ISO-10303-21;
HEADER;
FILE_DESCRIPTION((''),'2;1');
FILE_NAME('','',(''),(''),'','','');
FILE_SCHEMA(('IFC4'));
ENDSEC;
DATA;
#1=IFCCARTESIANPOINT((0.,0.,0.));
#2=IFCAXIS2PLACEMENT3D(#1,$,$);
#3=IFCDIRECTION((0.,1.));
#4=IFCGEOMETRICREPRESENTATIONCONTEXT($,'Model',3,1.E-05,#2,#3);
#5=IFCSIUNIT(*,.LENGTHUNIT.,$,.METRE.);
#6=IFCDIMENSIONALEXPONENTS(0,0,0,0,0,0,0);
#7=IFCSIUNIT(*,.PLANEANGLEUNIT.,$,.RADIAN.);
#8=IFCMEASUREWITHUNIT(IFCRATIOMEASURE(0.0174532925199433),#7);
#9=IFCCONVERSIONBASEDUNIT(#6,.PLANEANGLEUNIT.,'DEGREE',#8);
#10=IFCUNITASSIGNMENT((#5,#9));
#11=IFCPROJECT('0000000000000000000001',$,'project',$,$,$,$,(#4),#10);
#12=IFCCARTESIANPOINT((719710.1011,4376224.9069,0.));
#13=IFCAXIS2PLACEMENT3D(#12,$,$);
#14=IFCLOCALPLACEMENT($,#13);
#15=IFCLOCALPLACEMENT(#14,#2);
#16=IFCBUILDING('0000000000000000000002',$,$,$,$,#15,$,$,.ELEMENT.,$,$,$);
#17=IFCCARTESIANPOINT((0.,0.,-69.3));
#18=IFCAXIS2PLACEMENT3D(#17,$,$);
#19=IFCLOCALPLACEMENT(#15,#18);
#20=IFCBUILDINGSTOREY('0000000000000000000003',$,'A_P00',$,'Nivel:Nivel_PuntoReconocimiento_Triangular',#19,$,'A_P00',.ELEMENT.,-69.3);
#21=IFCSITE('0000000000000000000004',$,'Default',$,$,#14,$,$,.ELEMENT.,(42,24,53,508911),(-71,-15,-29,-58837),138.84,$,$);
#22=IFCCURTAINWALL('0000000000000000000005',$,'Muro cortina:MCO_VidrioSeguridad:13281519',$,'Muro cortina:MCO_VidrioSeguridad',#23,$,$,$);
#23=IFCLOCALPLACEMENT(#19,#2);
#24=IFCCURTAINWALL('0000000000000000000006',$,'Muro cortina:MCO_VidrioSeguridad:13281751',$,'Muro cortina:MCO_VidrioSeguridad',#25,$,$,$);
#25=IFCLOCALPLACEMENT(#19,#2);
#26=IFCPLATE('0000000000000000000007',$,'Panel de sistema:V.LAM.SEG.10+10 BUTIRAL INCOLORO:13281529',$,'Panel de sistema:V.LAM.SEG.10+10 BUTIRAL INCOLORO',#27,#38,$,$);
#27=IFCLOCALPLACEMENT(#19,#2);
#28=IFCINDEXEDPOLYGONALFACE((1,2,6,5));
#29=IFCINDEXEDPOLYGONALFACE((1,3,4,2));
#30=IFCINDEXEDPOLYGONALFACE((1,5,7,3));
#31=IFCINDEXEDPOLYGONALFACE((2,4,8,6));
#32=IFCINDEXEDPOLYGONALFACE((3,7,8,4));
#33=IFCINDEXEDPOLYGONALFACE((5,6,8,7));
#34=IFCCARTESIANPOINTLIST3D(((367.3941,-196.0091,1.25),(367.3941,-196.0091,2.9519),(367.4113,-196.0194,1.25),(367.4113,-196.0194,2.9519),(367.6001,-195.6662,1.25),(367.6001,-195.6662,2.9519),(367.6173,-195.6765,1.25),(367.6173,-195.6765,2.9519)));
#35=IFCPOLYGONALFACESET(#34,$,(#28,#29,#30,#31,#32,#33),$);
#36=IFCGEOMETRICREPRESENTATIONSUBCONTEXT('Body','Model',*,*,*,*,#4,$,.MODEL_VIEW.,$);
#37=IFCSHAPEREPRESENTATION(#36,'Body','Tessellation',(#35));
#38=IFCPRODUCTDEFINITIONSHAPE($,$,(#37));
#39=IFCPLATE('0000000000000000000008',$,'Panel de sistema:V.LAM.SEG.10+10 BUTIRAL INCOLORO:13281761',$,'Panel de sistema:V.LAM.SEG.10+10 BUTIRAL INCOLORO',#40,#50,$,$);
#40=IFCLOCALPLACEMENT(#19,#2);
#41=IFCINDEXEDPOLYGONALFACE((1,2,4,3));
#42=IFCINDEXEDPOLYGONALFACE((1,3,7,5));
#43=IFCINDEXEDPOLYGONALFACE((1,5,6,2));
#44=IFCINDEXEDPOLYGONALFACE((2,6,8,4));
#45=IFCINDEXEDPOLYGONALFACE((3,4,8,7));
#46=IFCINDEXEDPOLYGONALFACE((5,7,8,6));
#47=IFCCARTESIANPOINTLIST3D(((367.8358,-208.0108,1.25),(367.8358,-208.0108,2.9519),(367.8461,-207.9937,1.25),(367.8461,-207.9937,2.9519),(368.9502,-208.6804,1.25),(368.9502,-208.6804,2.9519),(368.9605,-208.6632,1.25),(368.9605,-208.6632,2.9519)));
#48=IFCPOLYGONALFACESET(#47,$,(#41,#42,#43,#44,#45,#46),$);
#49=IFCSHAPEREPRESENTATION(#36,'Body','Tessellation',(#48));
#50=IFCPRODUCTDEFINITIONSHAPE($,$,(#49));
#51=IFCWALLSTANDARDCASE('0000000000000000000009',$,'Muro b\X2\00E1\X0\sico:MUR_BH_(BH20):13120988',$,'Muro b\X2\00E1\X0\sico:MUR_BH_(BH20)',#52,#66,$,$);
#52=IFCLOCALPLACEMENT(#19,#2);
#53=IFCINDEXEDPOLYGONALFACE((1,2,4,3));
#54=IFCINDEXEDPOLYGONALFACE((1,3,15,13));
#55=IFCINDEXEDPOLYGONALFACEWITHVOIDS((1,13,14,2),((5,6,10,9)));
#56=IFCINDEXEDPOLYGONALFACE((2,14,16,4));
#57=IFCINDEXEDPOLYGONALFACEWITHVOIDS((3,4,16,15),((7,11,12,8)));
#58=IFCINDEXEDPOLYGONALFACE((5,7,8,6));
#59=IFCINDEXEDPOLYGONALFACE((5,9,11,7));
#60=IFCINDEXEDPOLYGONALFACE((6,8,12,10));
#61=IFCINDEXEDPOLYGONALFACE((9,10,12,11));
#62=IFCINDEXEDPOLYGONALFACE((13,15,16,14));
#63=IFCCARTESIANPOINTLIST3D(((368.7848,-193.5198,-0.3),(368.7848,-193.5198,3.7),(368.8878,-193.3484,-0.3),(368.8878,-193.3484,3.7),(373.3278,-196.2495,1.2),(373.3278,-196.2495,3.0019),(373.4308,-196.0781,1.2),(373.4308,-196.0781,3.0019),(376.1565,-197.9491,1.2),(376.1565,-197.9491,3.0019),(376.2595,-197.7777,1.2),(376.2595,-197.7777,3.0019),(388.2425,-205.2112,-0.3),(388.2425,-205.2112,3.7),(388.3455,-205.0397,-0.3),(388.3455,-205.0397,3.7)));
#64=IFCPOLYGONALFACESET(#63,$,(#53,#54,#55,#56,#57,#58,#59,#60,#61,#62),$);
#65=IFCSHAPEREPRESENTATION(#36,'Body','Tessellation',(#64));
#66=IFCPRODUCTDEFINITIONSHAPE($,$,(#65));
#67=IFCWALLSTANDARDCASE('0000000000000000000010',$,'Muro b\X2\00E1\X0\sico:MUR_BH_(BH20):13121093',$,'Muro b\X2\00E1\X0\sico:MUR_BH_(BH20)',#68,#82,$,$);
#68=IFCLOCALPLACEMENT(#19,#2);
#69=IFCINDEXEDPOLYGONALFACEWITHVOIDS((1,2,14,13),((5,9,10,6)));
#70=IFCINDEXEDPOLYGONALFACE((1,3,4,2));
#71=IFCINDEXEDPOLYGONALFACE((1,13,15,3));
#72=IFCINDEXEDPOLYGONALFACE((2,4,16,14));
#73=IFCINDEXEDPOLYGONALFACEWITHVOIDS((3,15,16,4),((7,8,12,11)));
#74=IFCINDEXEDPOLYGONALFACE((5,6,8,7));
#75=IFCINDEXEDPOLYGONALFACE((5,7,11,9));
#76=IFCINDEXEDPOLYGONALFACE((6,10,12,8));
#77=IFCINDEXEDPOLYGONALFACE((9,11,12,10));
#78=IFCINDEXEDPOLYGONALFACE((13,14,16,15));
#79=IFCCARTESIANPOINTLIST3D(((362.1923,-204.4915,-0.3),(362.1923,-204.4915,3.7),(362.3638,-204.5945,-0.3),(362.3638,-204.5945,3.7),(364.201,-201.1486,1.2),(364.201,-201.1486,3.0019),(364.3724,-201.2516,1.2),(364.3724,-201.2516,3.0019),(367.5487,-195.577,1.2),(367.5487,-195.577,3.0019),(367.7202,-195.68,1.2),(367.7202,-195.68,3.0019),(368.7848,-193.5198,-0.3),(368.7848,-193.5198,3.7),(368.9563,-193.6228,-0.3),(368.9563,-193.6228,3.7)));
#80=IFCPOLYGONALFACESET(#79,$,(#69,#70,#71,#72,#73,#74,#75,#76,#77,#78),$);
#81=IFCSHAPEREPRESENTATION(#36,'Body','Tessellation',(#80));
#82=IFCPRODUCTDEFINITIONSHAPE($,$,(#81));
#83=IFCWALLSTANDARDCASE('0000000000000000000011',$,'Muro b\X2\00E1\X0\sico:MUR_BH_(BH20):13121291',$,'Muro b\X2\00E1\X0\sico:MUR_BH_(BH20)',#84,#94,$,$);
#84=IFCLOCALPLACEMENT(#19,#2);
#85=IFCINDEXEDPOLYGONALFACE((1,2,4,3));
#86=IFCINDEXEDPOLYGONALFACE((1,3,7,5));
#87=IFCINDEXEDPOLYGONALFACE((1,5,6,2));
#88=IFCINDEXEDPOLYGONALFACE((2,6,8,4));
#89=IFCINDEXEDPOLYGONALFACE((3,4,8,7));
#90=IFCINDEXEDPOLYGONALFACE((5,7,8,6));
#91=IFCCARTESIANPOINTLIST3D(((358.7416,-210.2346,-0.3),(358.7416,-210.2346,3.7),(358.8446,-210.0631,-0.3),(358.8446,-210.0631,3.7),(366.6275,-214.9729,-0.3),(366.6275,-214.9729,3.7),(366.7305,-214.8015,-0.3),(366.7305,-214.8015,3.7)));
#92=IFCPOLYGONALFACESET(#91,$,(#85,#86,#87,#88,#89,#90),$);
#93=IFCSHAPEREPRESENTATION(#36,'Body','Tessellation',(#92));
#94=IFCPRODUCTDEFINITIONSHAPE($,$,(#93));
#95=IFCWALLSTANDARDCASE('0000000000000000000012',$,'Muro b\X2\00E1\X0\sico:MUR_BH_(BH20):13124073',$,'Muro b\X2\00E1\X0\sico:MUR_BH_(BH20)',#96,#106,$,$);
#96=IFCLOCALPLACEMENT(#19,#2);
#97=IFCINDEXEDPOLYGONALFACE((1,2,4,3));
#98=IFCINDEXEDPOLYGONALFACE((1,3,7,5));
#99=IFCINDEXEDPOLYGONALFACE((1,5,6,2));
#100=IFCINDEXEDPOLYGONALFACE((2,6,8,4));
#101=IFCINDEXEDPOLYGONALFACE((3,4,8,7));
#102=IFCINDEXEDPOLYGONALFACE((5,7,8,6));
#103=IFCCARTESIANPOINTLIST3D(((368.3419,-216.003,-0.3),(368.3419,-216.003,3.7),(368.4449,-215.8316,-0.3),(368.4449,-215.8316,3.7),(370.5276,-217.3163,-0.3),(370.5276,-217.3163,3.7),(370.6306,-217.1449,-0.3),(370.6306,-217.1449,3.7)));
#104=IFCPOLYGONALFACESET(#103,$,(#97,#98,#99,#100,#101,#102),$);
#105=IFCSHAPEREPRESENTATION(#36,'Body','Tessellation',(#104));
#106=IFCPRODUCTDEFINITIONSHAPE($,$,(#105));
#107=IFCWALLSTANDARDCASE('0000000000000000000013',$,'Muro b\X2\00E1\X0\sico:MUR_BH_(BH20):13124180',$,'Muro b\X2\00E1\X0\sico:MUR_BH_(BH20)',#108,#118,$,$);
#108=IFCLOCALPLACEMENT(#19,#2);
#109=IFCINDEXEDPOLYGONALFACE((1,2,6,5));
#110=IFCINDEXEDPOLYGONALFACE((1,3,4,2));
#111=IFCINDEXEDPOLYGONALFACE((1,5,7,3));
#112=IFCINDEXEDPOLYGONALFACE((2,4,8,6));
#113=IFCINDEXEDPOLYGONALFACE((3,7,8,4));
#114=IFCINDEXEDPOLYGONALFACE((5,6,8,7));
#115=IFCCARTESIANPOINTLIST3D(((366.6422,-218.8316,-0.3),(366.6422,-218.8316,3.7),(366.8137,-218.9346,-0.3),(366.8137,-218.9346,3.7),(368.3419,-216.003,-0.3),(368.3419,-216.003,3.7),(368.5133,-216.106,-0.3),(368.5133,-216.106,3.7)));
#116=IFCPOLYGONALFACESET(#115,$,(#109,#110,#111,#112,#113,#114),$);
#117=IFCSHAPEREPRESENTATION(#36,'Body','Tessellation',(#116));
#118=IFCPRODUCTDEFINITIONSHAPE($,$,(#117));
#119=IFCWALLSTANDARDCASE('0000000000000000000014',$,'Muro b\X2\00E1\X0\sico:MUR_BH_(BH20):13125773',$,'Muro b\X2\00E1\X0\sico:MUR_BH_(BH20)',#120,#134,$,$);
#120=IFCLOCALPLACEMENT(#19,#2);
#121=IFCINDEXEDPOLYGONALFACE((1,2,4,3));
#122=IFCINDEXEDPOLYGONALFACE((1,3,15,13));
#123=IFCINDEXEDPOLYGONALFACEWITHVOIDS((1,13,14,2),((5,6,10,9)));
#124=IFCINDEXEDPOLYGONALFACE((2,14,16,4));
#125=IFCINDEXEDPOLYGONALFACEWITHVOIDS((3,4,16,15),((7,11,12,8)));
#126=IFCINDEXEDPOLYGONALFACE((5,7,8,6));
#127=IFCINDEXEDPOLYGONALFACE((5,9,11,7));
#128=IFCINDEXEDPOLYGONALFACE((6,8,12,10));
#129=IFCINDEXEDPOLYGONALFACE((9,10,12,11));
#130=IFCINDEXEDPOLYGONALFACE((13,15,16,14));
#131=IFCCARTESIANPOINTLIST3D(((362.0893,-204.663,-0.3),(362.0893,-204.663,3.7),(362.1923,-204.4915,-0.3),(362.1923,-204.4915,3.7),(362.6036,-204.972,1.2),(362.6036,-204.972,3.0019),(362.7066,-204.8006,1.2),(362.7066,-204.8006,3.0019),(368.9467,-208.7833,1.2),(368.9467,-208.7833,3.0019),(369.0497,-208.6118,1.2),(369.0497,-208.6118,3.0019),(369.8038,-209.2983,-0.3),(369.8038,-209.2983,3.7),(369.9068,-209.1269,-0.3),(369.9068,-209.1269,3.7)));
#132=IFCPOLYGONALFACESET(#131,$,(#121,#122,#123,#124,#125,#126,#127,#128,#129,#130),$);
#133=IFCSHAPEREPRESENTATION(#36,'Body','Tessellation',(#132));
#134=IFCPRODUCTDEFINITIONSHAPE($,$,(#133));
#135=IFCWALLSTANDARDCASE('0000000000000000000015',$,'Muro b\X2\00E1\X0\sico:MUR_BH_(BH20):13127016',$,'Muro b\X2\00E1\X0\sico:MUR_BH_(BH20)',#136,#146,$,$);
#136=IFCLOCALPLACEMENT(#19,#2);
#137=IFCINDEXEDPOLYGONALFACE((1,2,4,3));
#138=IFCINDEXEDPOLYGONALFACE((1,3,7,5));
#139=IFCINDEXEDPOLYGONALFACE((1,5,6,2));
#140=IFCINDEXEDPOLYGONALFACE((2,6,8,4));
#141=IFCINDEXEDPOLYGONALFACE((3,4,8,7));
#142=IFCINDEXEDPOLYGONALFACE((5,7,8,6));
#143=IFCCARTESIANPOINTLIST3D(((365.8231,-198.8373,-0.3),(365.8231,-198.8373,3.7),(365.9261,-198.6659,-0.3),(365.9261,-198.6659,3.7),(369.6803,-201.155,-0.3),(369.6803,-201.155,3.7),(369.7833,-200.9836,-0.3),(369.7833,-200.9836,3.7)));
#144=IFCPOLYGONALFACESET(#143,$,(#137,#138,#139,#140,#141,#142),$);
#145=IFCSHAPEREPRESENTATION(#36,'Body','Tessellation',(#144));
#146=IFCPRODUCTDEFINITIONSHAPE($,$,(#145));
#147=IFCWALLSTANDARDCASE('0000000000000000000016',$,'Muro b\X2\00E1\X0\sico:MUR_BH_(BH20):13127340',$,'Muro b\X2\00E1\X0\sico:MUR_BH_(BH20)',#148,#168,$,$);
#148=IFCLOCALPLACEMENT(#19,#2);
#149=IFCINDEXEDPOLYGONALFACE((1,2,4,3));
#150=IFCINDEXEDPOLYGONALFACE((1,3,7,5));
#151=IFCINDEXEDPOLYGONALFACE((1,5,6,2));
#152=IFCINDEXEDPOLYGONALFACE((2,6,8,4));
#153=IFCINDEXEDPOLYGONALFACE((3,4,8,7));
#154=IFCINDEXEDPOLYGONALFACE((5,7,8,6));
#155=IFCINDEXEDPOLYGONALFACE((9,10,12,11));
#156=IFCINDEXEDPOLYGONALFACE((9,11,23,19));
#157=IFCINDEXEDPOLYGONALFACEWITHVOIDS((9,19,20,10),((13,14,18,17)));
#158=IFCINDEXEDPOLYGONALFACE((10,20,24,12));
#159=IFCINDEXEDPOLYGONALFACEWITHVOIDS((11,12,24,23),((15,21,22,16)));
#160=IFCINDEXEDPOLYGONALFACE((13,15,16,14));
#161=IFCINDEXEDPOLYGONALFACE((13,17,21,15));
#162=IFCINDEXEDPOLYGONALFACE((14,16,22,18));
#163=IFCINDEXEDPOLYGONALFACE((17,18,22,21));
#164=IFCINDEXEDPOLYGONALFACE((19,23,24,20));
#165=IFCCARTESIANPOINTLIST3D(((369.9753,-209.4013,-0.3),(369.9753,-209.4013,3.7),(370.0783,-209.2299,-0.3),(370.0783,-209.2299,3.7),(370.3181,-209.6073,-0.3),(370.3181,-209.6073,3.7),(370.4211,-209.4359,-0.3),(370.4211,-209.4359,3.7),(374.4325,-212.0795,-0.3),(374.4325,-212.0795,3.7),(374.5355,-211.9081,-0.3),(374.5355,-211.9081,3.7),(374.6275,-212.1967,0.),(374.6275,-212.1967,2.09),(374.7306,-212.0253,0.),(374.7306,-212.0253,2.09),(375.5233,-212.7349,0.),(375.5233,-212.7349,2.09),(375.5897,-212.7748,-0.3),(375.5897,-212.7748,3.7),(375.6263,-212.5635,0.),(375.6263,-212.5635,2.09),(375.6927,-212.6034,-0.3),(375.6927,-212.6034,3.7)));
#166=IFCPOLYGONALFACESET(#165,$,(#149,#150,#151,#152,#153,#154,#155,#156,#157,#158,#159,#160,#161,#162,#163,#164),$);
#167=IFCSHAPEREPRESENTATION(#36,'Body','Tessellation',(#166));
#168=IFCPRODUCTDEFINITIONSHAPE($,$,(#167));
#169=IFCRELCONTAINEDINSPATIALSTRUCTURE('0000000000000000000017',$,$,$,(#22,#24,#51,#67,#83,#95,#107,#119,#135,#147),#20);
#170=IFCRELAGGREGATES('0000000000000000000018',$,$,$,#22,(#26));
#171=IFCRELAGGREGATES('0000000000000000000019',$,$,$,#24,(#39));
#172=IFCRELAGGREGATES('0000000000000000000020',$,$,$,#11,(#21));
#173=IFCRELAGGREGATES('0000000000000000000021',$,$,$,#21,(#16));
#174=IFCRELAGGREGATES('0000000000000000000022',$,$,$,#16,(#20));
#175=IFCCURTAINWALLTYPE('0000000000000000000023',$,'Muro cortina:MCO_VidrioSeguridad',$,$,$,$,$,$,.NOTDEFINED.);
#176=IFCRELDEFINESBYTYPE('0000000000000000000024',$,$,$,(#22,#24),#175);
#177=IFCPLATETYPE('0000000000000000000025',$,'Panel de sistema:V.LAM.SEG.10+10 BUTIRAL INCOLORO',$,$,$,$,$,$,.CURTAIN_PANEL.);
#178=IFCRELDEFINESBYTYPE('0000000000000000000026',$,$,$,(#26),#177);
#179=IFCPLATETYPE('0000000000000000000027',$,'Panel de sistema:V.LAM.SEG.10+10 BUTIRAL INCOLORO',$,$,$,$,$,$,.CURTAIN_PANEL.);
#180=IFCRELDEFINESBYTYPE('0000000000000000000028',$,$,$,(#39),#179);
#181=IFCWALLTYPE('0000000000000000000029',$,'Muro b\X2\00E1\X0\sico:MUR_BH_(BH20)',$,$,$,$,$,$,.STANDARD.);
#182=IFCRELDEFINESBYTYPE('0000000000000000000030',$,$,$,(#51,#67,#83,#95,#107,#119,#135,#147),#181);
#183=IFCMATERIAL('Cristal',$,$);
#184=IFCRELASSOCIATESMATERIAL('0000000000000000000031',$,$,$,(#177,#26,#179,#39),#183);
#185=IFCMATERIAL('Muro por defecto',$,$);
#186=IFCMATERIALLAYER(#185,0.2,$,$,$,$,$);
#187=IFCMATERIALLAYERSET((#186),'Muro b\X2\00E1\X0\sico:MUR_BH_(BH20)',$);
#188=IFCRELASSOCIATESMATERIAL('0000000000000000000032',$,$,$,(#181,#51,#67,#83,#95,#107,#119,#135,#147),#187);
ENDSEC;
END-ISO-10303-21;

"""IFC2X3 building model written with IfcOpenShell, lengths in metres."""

from ifc_helpers import new_model, entity, si_unit, converted_unit, direction, frame, frame_2d, origin, origin_2d_with_axis, place, context, subcontext, project, spatial, rectangle, extrude, source, transform, mapped, material, layer, layer_set, layer_usage, type_object, type_shapes, element, aggregate, save


model = new_model("IFC2X3")

# Units and contexts
model_context = context("Model", 3, precision=1e-05, world=origin(), true_north=direction((0.0, 1.0)))
body_context = subcontext(model_context, "Body", "Model", "MODEL_VIEW")
ifc_project = project(units=[si_unit("LENGTHUNIT", "METRE"), converted_unit("PLANEANGLEUNIT", "DEGREE", entity("IfcRatioMeasure", 0.0174532925199433), si_unit("PLANEANGLEUNIT", "RADIAN"), dimensions=[0, 0, 0, 0, 0, 0, 0])], contexts=[model_context])

# Site, building, storey
site_placement = place(None, frame((719710.1011, 4376224.9069, 0.0)))
site = spatial("IfcSite", under=ifc_project, at=site_placement, Name="Default", CompositionType="ELEMENT", RefLatitude=(42, 24, 53, 508911), RefLongitude=(-71, -15, -29, -58837), RefElevation=138.84)
building_placement = place(site_placement, origin())
building = spatial("IfcBuilding", under=site, at=building_placement, CompositionType="ELEMENT")
storey_placement = place(building_placement, frame((0.0, 0.0, -69.3)))
storey = spatial("IfcBuildingStorey", under=building, at=storey_placement, Name="A_P00", ObjectType="Nivel:Nivel_PuntoReconocimiento_Triangular", LongName="A_P00", CompositionType="ELEMENT", Elevation=-69.3)

# Curtain walls
curtain_wall_type = type_object("IfcCurtainWallType", Name="Muro cortina:MCO_VidrioSeguridad", PredefinedType="NOTDEFINED")
ifc_material_1 = material(Name="Cristal")
curtain_wall_1_placement = place(storey_placement, frame((0.0, 0.0, 69.3)))
curtain_wall_1 = element("IfcCurtainWall", 1, at=curtain_wall_1_placement, inside=storey, type_object=curtain_wall_type, Name="Muro cortina:MCO_VidrioSeguridad:13281519", ObjectType="Muro cortina:MCO_VidrioSeguridad")
curtain_wall_2_placement = place(storey_placement, frame((0.0, 0.0, 69.3)))
curtain_wall_2 = element("IfcCurtainWall", 2, at=curtain_wall_2_placement, inside=storey, type_object=curtain_wall_type, Name="Muro cortina:MCO_VidrioSeguridad:13281751", ObjectType="Muro cortina:MCO_VidrioSeguridad")

# Plates
plate_type_1 = type_object("IfcPlateType", Name="Panel de sistema:V.LAM.SEG.10+10 BUTIRAL INCOLORO", PredefinedType="CURTAIN_PANEL", material=ifc_material_1)
shared_shape_1 = source(origin(), body_context, "Body", "SweptSolid", [
    extrude(rectangle(XDim=0.02, YDim=0.4, at=origin_2d_with_axis()), frame((0.0, 0.0, 0.0), z_axis=(0.0, 0.0, 1.0), x_axis=(0.0, 1.0, 0.0)), (0.0, 0.0, 1.0), 1.7019),
])
type_shapes(plate_type_1, [shared_shape_1])
plate_1_placement = place(curtain_wall_1_placement, frame((367.5057, -195.8428, -68.05), z_axis=(0.0, 0.0, 1.0), x_axis=(0.515038, 0.857167, 0.0)))
plate_1 = element("IfcPlate", 3, at=plate_1_placement, type_object=plate_type_1, material=ifc_material_1, Name="Panel de sistema:V.LAM.SEG.10+10 BUTIRAL INCOLORO:13281529", ObjectType="Panel de sistema:V.LAM.SEG.10+10 BUTIRAL INCOLORO", context=body_context, shape_type="MappedRepresentation", body=[
    mapped(shared_shape_1, transform((0.0, 0.0, 0.0), scale=1.0)),
])
aggregate(curtain_wall_1, [plate_1])
plate_type_2 = type_object("IfcPlateType", Name="Panel de sistema:V.LAM.SEG.10+10 BUTIRAL INCOLORO", PredefinedType="CURTAIN_PANEL", material=ifc_material_1)
shared_shape_2 = source(origin(), body_context, "Body", "SweptSolid", [
    extrude(rectangle(XDim=0.02, YDim=1.3, at=origin_2d_with_axis()), frame((0.0, 0.0, 0.0), z_axis=(0.0, 0.0, 1.0), x_axis=(0.0, 1.0, 0.0)), (0.0, 0.0, 1.0), 1.7019),
])
type_shapes(plate_type_2, [shared_shape_2])
plate_2_placement = place(curtain_wall_2_placement, frame((368.3982, -208.337, -68.05), z_axis=(0.0, 0.0, 1.0), x_axis=(0.857167, -0.515038, 0.0)))
plate_2 = element("IfcPlate", 4, at=plate_2_placement, type_object=plate_type_2, material=ifc_material_1, Name="Panel de sistema:V.LAM.SEG.10+10 BUTIRAL INCOLORO:13281761", ObjectType="Panel de sistema:V.LAM.SEG.10+10 BUTIRAL INCOLORO", context=body_context, shape_type="MappedRepresentation", body=[
    mapped(shared_shape_2, transform((0.0, 0.0, 0.0), scale=1.0)),
])
aggregate(curtain_wall_2, [plate_2])

# Walls, openings
ifc_material_2 = material(Name="Muro por defecto")
ifc_layer = layer(ifc_material_2, 0.2)
ifc_layer_set = layer_set([ifc_layer], Name="Muro básico:MUR_BH_(BH20)")
ifc_layer_usage_1 = layer_usage(ifc_layer_set, "AXIS2", "NEGATIVE", 0.1)
wall_type = type_object("IfcWallType", Name="Muro básico:MUR_BH_(BH20)", PredefinedType="STANDARD", material=ifc_layer_set)
wall_1_placement = place(storey_placement, frame((368.8363, -193.4341, -0.3), z_axis=(0.0, 0.0, 1.0), x_axis=(0.857167, -0.515038, 0.0)))
wall_1 = element("IfcWallStandardCase", 5, at=wall_1_placement, inside=storey, type_object=wall_type, material=ifc_layer_usage_1, Name="Muro básico:MUR_BH_(BH20):13120988", ObjectType="Muro básico:MUR_BH_(BH20)", context=body_context, shape_type="SweptSolid", body=[
    extrude(rectangle(XDim=22.7, YDim=0.2, at=frame_2d((11.35, 0.0), x_axis=(-1.0, 0.0))), origin(), (0.0, 0.0, 1.0), 4.0),
])
opening_1_placement = place(wall_1_placement, origin())
element("IfcOpeningElement", 6, at=opening_1_placement, cuts=wall_1, ObjectType="Opening", context=body_context, shape_type="SweptSolid", body=[
    extrude(rectangle(XDim=1.8019, YDim=3.3, at=frame_2d((0.0, 0.0), x_axis=(1.0, 0.0))), frame((6.95, -0.2524, 2.4009), z_axis=(0.0, 1.0, 0.0), x_axis=(0.0, 0.0, 1.0)), (0.0, 0.0, 1.0), 0.5048),
])
ifc_layer_usage_2 = layer_usage(ifc_layer_set, "AXIS2", "NEGATIVE", 0.1)
wall_2_placement = place(storey_placement, frame((362.2781, -204.543, -0.3), z_axis=(0.0, 0.0, 1.0), x_axis=(0.515038, 0.857167, 0.0)))
wall_2 = element("IfcWallStandardCase", 7, at=wall_2_placement, inside=storey, type_object=wall_type, material=ifc_layer_usage_2, Name="Muro básico:MUR_BH_(BH20):13121093", ObjectType="Muro básico:MUR_BH_(BH20)", context=body_context, shape_type="SweptSolid", body=[
    extrude(rectangle(XDim=12.8, YDim=0.2, at=frame_2d((6.4, 0.0), x_axis=(-1.0, 0.0))), origin(), (0.0, 0.0, 1.0), 4.0),
])
opening_2_placement = place(wall_2_placement, origin())
element("IfcOpeningElement", 8, at=opening_2_placement, cuts=wall_2, ObjectType="Opening", context=body_context, shape_type="SweptSolid", body=[
    extrude(rectangle(XDim=1.8019, YDim=6.5, at=frame_2d((0.0, 0.0), x_axis=(1.0, 0.0))), frame((7.15, -0.2524, 2.4009), z_axis=(0.0, 1.0, 0.0), x_axis=(0.0, 0.0, 1.0)), (0.0, 0.0, 1.0), 0.5048),
])

# Wall
ifc_layer_usage_3 = layer_usage(ifc_layer_set, "AXIS2", "NEGATIVE", 0.1)
wall_3_placement = place(storey_placement, frame((358.7931, -210.1488, -0.3), z_axis=(0.0, 0.0, 1.0), x_axis=(0.857167, -0.515038, 0.0)))
element("IfcWallStandardCase", 9, at=wall_3_placement, inside=storey, type_object=wall_type, material=ifc_layer_usage_3, Name="Muro básico:MUR_BH_(BH20):13121291", ObjectType="Muro básico:MUR_BH_(BH20)", context=body_context, shape_type="SweptSolid", body=[
    extrude(rectangle(XDim=9.2, YDim=0.2, at=frame_2d((4.6, 0.0), x_axis=(-1.0, 0.0))), origin(), (0.0, 0.0, 1.0), 4.0),
])

# Walls
ifc_layer_usage_4 = layer_usage(ifc_layer_set, "AXIS2", "NEGATIVE", 0.1)
wall_4_placement = place(storey_placement, frame((368.3934, -215.9173, -0.3), z_axis=(0.0, 0.0, 1.0), x_axis=(0.857167, -0.515038, 0.0)))
element("IfcWallStandardCase", 10, at=wall_4_placement, inside=storey, type_object=wall_type, material=ifc_layer_usage_4, Name="Muro básico:MUR_BH_(BH20):13124073", ObjectType="Muro básico:MUR_BH_(BH20)", context=body_context, shape_type="SweptSolid", body=[
    extrude(rectangle(XDim=2.55, YDim=0.2, at=frame_2d((1.275, 0.0), x_axis=(-1.0, 0.0))), origin(), (0.0, 0.0, 1.0), 4.0),
])
ifc_layer_usage_5 = layer_usage(ifc_layer_set, "AXIS2", "NEGATIVE", 0.1)
wall_5_placement = place(storey_placement, frame((368.4276, -216.0545, -0.3), z_axis=(0.0, 0.0, 1.0), x_axis=(-0.515038, -0.857167, 0.0)))
element("IfcWallStandardCase", 11, at=wall_5_placement, inside=storey, type_object=wall_type, material=ifc_layer_usage_5, Name="Muro básico:MUR_BH_(BH20):13124180", ObjectType="Muro básico:MUR_BH_(BH20)", context=body_context, shape_type="SweptSolid", body=[
    extrude(rectangle(XDim=3.3, YDim=0.2, at=frame_2d((1.65, 0.0), x_axis=(-1.0, 0.0))), origin(), (0.0, 0.0, 1.0), 4.0),
])

# Wall, opening
ifc_layer_usage_6 = layer_usage(ifc_layer_set, "AXIS2", "NEGATIVE", 0.1)
wall_6_placement = place(storey_placement, frame((369.8553, -209.2126, -0.3), z_axis=(0.0, 0.0, 1.0), x_axis=(-0.857167, 0.515038, 0.0)))
wall_6 = element("IfcWallStandardCase", 12, at=wall_6_placement, inside=storey, type_object=wall_type, material=ifc_layer_usage_6, Name="Muro básico:MUR_BH_(BH20):13125773", ObjectType="Muro básico:MUR_BH_(BH20)", context=body_context, shape_type="SweptSolid", body=[
    extrude(rectangle(XDim=9.0, YDim=0.2, at=frame_2d((4.5, 0.0), x_axis=(-1.0, 0.0))), origin(), (0.0, 0.0, 1.0), 4.0),
])
opening_3_placement = place(wall_6_placement, origin())
element("IfcOpeningElement", 13, at=opening_3_placement, cuts=wall_6, ObjectType="Opening", context=body_context, shape_type="SweptSolid", body=[
    extrude(rectangle(XDim=1.8019, YDim=7.4, at=frame_2d((0.0, 0.0), x_axis=(0.0, 1.0))), frame((4.7, -0.2524, 2.4009), z_axis=(0.0, 1.0, 0.0), x_axis=(-1.0, 0.0, 0.0)), (0.0, 0.0, 1.0), 0.5048),
])

# Wall
ifc_layer_usage_7 = layer_usage(ifc_layer_set, "AXIS2", "NEGATIVE", 0.1)
wall_7_placement = place(storey_placement, frame((369.7318, -201.0693, -0.3), z_axis=(0.0, 0.0, 1.0), x_axis=(-0.857167, 0.515038, 0.0)))
element("IfcWallStandardCase", 14, at=wall_7_placement, inside=storey, type_object=wall_type, material=ifc_layer_usage_7, Name="Muro básico:MUR_BH_(BH20):13127016", ObjectType="Muro básico:MUR_BH_(BH20)", context=body_context, shape_type="SweptSolid", body=[
    extrude(rectangle(XDim=4.5, YDim=0.2, at=frame_2d((2.25, 0.0), x_axis=(-1.0, 0.0))), origin(), (0.0, 0.0, 1.0), 4.0),
])

# Wall, openings
ifc_layer_usage_8 = layer_usage(ifc_layer_set, "AXIS2", "NEGATIVE", 0.1)
wall_8_placement = place(storey_placement, frame((370.0268, -209.3156, -0.3), z_axis=(0.0, 0.0, 1.0), x_axis=(0.857167, -0.515038, 0.0)))
wall_8 = element("IfcWallStandardCase", 15, at=wall_8_placement, inside=storey, type_object=wall_type, material=ifc_layer_usage_8, Name="Muro básico:MUR_BH_(BH20):13127340", ObjectType="Muro básico:MUR_BH_(BH20)", context=body_context, shape_type="SweptSolid", body=[
    extrude(rectangle(XDim=6.55, YDim=0.2, at=frame_2d((3.275, 0.0), x_axis=(-1.0, 0.0))), origin(), (0.0, 0.0, 1.0), 4.0),
])
opening_4_placement = place(wall_8_placement, origin())
element("IfcOpeningElement", 16, at=opening_4_placement, cuts=wall_8, ObjectType="Opening", context=body_context, shape_type="SweptSolid", body=[
    extrude(rectangle(XDim=4.0, YDim=4.8, at=frame_2d((0.0, 0.0), x_axis=(1.0, 0.0))), frame((2.8, -0.2524, 2.0), z_axis=(0.0, 1.0, 0.0), x_axis=(0.0, 0.0, 1.0)), (0.0, 0.0, 1.0), 0.5048),
])
opening_5_placement = place(wall_8_placement, frame((-424.9804, -11.1594, 0.3), z_axis=(0.0, 0.0, 1.0), x_axis=(0.857167, 0.515038, 0.0)))
element("IfcOpeningElement", 17, at=opening_5_placement, cuts=wall_8, ObjectType="Opening", context=body_context, shape_type="SweptSolid", body=[
    extrude(rectangle(XDim=2.09, YDim=1.045, at=frame_2d((0.0, 0.0), x_axis=(1.0, 0.0))), frame((375.0754, -212.4658, 1.045), z_axis=(0.515038, 0.857167, 0.0), x_axis=(0.0, 0.0, -1.0)), (0.0, 0.0, 1.0), 0.2),
])

save(model, "model.ifc")
